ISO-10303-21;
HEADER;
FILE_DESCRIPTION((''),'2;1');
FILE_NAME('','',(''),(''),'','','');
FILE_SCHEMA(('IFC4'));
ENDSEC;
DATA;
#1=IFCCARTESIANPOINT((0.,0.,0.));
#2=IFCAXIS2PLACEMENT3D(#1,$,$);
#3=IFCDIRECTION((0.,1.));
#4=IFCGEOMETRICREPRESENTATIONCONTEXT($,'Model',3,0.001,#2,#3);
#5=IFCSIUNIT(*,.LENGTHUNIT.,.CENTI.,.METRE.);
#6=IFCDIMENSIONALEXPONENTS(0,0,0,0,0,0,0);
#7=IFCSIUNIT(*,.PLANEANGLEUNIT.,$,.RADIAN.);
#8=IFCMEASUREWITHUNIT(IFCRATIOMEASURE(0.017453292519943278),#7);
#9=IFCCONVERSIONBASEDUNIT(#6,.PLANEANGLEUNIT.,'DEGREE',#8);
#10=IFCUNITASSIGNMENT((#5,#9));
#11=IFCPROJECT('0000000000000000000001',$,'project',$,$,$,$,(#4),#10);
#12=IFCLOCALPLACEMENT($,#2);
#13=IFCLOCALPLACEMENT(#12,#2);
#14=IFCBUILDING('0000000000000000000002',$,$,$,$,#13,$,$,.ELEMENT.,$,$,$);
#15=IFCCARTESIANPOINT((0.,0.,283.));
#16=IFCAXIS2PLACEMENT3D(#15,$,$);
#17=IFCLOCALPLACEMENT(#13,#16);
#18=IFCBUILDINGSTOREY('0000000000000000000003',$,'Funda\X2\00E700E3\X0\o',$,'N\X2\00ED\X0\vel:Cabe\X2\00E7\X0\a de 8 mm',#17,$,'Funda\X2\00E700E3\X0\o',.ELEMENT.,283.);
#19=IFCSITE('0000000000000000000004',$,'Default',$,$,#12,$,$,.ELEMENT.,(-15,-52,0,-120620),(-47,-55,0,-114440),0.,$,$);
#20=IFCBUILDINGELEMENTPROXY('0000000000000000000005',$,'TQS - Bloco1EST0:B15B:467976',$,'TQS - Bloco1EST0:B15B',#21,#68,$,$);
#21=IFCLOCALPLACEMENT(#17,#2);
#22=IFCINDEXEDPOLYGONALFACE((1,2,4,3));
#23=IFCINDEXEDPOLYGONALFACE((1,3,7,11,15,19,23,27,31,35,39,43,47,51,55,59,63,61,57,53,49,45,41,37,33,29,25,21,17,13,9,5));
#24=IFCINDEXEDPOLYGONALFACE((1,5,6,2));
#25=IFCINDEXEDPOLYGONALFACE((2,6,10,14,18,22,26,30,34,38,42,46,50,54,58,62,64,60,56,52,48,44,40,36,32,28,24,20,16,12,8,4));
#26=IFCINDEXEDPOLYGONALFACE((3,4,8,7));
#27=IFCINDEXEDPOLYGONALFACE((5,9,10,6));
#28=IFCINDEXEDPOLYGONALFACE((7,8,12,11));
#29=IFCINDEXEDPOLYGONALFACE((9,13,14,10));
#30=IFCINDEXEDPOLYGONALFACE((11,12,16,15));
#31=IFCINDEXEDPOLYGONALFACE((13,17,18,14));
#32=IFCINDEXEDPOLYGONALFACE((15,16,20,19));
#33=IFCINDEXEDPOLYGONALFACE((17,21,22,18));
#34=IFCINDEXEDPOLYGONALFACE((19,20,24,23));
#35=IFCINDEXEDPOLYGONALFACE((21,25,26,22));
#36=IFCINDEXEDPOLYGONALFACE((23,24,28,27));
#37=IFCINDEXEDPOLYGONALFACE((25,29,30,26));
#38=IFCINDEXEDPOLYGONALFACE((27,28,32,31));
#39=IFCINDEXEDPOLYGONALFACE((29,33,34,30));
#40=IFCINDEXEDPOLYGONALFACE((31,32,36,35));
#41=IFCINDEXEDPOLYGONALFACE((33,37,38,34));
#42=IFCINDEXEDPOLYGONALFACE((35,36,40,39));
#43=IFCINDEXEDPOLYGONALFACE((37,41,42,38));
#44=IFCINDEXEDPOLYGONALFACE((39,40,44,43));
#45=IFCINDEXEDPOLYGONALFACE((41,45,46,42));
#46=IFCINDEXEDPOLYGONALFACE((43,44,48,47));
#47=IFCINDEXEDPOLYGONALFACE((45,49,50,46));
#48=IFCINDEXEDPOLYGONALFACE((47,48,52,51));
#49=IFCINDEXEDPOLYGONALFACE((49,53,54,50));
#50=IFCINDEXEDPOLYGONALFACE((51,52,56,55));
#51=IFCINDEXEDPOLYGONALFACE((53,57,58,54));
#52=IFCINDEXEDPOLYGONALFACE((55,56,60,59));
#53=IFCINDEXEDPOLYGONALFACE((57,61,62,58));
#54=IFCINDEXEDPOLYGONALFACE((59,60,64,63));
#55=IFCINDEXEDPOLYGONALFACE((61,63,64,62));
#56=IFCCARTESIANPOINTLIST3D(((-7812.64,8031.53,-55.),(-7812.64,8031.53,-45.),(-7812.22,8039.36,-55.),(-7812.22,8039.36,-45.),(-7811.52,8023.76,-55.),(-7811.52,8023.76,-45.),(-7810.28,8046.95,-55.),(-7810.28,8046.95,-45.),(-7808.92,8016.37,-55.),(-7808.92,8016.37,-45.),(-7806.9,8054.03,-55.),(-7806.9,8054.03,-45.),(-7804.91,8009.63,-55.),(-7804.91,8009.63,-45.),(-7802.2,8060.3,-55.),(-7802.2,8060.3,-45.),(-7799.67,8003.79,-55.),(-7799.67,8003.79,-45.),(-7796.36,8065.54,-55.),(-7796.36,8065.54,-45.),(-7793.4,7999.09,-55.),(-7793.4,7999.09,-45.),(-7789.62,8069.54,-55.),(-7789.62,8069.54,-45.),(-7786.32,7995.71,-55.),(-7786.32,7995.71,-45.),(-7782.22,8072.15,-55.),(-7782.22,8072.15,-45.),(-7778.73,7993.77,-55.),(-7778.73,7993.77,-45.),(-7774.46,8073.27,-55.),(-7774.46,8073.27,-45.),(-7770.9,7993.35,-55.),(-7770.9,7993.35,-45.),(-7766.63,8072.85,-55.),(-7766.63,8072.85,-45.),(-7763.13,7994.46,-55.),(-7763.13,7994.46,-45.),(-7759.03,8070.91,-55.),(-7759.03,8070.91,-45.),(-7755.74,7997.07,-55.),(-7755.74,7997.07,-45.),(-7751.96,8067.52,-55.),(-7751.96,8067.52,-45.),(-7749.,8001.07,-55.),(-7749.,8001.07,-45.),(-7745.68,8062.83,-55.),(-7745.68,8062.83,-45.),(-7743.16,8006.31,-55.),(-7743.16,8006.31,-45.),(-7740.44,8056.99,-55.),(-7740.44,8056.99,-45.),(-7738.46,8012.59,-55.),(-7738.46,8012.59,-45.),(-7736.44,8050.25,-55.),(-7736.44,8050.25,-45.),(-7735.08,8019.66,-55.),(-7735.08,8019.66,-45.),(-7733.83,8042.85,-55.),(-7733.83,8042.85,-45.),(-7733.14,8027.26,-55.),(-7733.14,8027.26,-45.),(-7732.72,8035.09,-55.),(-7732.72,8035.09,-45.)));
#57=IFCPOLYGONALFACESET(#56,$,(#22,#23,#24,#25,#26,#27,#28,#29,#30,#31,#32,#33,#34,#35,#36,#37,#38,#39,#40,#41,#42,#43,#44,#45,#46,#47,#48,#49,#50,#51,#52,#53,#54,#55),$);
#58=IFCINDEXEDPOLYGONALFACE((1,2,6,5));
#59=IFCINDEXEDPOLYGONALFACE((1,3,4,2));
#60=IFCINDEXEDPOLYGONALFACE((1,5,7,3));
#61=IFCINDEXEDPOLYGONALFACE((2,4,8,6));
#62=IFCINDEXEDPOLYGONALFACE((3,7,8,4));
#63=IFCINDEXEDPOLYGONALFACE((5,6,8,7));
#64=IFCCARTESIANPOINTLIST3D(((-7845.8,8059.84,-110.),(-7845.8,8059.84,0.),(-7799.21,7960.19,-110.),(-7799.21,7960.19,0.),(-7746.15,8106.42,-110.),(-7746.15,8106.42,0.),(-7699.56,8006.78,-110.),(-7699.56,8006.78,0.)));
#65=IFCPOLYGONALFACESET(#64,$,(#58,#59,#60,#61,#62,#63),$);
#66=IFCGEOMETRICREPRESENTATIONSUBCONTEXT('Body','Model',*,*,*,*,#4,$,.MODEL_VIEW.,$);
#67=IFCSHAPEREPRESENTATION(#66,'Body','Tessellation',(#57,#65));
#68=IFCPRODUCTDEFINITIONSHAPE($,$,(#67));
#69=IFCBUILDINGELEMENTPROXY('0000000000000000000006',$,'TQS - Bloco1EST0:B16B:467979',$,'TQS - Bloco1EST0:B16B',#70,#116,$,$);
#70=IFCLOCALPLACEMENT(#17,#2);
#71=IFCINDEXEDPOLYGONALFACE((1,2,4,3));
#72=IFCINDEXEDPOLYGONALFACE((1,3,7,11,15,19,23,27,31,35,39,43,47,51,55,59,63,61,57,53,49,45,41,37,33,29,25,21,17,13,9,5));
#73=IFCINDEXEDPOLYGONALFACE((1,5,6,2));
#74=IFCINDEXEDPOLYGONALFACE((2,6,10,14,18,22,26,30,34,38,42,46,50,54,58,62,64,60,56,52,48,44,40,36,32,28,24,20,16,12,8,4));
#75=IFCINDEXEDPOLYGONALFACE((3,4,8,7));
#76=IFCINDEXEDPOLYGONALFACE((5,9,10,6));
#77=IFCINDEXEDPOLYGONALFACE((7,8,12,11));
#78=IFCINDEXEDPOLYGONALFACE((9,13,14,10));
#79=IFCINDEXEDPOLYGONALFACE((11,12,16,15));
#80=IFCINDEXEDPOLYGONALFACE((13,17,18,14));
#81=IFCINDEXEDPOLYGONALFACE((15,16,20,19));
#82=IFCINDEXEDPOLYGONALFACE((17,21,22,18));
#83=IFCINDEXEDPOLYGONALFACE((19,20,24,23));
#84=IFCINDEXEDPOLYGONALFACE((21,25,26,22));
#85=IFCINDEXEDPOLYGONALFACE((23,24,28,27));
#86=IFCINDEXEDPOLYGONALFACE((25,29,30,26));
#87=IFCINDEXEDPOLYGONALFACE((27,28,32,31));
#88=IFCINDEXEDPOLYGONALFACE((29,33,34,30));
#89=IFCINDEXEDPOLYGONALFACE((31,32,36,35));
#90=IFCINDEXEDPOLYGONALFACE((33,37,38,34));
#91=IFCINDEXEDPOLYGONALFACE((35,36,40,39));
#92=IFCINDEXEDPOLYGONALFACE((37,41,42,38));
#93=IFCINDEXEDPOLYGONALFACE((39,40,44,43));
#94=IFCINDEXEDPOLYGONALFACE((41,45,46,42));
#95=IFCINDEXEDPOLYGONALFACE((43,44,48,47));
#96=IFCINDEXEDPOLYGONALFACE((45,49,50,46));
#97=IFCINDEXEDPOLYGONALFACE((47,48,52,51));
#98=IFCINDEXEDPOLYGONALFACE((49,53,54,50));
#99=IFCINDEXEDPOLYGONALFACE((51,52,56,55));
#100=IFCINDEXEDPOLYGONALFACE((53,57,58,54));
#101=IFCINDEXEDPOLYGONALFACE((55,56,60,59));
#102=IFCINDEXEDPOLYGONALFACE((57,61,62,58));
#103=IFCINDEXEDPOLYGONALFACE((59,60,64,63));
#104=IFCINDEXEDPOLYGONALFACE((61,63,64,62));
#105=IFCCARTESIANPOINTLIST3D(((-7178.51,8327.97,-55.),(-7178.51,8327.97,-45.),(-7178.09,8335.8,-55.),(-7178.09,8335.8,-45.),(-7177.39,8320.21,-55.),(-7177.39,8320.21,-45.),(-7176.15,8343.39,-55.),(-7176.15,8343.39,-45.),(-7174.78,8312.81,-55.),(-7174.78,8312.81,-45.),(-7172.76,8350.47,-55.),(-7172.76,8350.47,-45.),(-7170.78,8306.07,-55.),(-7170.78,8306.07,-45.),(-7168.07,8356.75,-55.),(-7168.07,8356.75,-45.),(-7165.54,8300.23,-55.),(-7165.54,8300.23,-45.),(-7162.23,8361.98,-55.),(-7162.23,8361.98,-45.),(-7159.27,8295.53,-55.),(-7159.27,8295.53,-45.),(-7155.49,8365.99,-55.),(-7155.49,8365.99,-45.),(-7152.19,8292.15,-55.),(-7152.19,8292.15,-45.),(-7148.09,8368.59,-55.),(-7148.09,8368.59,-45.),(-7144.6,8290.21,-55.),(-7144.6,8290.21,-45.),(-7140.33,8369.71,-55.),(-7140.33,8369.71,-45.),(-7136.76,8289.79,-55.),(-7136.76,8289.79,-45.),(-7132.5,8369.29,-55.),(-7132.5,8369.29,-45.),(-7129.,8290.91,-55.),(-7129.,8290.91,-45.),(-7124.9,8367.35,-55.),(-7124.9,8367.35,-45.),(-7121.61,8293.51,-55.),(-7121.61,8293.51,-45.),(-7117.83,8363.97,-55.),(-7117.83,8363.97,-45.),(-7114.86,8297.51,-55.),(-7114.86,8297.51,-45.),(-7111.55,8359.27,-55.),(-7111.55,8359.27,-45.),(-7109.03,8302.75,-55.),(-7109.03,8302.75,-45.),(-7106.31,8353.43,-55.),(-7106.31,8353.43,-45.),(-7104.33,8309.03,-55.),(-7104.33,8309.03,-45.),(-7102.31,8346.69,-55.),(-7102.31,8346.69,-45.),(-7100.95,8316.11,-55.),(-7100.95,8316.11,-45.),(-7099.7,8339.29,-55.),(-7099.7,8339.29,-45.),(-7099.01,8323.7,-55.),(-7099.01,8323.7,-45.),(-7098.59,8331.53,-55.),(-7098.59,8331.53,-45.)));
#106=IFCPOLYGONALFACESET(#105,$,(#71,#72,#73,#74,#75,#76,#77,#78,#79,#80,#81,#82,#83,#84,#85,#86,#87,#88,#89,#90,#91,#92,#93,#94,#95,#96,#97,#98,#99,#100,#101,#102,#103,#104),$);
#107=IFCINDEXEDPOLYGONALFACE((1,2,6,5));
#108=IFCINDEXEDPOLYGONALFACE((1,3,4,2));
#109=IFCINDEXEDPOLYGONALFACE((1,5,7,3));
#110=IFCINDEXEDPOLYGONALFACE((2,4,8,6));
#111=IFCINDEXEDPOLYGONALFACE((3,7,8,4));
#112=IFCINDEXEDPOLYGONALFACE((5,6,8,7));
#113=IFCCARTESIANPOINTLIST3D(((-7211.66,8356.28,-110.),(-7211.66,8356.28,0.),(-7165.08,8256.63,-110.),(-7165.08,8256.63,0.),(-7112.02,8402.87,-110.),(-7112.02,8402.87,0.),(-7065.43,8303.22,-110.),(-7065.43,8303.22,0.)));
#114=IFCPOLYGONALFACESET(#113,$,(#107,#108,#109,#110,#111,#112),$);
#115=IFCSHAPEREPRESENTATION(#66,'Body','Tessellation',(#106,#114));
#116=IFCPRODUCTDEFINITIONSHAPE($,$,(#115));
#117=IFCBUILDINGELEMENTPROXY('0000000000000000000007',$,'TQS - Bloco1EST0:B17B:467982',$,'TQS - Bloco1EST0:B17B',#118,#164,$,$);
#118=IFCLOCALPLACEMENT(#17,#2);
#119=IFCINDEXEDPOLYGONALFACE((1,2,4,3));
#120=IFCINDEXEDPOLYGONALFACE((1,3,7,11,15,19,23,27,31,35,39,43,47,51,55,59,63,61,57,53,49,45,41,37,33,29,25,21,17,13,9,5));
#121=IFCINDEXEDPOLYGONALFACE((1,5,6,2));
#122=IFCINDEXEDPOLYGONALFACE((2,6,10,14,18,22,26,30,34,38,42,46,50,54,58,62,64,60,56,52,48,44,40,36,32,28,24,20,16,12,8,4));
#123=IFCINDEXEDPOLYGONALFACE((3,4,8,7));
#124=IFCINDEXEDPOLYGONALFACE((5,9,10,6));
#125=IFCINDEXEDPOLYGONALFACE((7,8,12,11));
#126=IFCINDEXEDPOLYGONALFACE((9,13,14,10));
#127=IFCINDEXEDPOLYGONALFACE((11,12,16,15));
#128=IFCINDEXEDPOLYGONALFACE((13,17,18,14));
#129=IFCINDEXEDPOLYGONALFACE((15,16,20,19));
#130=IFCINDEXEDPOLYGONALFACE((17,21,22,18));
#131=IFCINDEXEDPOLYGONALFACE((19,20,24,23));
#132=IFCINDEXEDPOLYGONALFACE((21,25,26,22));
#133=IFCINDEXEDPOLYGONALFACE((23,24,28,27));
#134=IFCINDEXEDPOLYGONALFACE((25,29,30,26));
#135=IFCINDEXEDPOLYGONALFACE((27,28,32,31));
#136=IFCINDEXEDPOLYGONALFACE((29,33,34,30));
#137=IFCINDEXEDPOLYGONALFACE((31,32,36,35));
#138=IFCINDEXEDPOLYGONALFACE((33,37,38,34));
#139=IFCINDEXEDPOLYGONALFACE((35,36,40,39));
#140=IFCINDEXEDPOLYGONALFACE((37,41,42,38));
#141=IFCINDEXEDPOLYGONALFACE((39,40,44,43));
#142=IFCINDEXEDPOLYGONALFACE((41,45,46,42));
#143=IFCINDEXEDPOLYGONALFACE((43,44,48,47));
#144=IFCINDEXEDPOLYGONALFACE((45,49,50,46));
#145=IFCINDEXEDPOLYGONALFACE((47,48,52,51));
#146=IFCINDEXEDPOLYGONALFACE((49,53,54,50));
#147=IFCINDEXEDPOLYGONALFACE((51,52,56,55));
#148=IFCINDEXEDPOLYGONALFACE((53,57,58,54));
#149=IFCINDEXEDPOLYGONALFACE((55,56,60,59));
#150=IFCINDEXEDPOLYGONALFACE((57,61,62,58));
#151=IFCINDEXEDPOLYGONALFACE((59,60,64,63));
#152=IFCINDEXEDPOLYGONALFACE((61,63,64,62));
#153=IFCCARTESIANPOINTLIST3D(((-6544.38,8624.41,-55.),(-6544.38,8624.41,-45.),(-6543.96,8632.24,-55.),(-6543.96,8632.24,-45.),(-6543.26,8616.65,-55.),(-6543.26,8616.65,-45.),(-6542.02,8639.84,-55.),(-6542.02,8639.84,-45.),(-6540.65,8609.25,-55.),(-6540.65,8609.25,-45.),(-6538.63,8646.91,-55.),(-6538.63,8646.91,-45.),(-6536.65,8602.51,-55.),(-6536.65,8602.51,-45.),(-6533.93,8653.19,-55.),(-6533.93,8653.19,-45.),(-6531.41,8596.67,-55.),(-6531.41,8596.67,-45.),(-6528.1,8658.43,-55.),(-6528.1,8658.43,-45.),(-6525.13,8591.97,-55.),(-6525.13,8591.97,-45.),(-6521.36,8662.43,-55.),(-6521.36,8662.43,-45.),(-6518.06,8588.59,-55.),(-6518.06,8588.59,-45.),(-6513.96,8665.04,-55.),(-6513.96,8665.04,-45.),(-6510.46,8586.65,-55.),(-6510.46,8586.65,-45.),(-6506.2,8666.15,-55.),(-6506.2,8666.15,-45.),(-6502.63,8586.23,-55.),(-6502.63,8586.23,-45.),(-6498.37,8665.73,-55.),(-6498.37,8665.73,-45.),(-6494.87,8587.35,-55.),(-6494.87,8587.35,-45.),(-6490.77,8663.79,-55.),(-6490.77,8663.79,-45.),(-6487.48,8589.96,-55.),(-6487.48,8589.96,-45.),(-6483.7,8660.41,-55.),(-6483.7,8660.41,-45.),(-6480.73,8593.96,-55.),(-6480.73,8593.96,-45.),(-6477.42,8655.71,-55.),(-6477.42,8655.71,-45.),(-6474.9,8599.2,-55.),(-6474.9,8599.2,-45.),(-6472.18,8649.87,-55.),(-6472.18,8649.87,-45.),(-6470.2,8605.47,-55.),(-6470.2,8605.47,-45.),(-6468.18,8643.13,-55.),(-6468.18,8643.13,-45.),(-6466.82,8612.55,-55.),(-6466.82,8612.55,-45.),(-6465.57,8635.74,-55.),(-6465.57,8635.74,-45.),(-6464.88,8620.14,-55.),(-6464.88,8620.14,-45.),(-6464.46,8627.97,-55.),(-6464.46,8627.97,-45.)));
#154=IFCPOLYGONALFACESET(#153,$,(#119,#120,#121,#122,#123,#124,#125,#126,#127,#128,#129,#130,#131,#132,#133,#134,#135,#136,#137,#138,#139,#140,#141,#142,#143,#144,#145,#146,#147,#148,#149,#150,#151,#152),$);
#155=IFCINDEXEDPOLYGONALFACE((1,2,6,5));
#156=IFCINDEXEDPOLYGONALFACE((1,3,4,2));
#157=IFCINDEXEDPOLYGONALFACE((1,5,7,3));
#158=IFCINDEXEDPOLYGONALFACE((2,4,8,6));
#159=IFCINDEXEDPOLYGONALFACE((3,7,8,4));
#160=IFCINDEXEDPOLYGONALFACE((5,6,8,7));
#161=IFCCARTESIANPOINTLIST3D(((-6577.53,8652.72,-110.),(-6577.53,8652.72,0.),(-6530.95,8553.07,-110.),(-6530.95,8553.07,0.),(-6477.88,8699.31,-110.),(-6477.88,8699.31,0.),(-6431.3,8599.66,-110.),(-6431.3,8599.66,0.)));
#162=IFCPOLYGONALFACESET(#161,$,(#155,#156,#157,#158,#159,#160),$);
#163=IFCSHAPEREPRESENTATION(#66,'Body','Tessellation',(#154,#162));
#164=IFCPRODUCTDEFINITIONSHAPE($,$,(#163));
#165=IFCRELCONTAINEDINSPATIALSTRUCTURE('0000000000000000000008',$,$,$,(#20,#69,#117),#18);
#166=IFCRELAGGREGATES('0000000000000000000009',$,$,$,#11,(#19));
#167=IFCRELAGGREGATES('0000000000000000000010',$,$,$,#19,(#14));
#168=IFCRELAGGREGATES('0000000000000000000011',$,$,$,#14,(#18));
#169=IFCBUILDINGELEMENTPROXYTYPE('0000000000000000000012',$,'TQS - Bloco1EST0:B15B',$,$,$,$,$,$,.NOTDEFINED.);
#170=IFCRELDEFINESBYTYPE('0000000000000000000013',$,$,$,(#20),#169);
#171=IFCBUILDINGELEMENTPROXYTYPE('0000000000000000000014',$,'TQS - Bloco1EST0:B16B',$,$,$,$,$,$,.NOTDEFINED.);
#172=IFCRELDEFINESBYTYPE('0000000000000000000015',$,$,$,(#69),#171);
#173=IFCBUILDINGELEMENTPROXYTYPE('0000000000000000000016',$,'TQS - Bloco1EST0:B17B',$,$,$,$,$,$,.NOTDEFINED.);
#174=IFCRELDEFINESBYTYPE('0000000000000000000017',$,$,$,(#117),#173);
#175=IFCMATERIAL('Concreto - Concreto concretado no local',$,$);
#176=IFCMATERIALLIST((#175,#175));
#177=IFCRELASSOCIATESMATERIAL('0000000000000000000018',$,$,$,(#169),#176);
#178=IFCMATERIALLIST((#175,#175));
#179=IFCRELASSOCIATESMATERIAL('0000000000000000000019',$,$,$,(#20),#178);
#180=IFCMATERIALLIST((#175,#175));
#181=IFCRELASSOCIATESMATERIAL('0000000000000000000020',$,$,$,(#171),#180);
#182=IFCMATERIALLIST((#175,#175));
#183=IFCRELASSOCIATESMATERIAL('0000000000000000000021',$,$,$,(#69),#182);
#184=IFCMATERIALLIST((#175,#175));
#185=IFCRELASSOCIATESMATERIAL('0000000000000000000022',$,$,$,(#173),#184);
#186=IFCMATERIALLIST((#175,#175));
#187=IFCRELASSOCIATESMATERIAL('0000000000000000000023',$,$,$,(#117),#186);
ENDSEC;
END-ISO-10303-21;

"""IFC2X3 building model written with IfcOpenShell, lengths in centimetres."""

from ifc_helpers import new_model, entity, si_unit, converted_unit, direction, frame, frame_2d, origin, origin_2d_with_axis, place, context, subcontext, project, spatial, rectangle, circle, extrude, source, transform, mapped, material, material_list, type_object, type_shapes, element, save


model = new_model("IFC2X3")

# Units and contexts
model_context = context("Model", 3, precision=0.001, world=origin(), true_north=direction((0.0, 1.0)))
body_context = subcontext(model_context, "Body", "Model", "MODEL_VIEW")
ifc_project = project(units=[si_unit("LENGTHUNIT", "METRE", prefix="CENTI"), converted_unit("PLANEANGLEUNIT", "DEGREE", entity("IfcRatioMeasure", 0.017453292519943278), si_unit("PLANEANGLEUNIT", "RADIAN"), dimensions=[0, 0, 0, 0, 0, 0, 0])], contexts=[model_context])

# Site, building, storey
site_placement = place(None, origin())
site = spatial("IfcSite", under=ifc_project, at=site_placement, Name="Default", CompositionType="ELEMENT", RefLatitude=(-15, -52, 0, -120620), RefLongitude=(-47, -55, 0, -114440), RefElevation=0.0)
building_placement = place(site_placement, origin())
building = spatial("IfcBuilding", under=site, at=building_placement, CompositionType="ELEMENT")
storey_placement = place(building_placement, frame((0.0, 0.0, 283.0)))
storey = spatial("IfcBuildingStorey", under=building, at=storey_placement, Name="Fundação", ObjectType="Nível:Cabeça de 8 mm", LongName="Fundação", CompositionType="ELEMENT", Elevation=283.0)

# Building element proxies
ifc_material_1 = material(Name="Concreto - Concreto concretado no local")
ifc_material_list_1 = material_list([ifc_material_1, ifc_material_1])
ifc_material_list_2 = material_list([ifc_material_1, ifc_material_1])
building_element_proxy_type_1 = type_object("IfcBuildingElementProxyType", Name="TQS - Bloco1EST0:B15B", PredefinedType="NOTDEFINED", material=ifc_material_list_2)
shared_shape_1 = source(origin(), body_context, "Body", "SweptSolid", [
    extrude(circle(Radius=40.0, at=frame_2d((0.0, 0.0), x_axis=(1.0, 0.0))), frame((0.0, 0.0, -55.0)), (0.0, 0.0, 1.0), 10.0),
    extrude(rectangle(XDim=110.0, YDim=110.0, at=origin_2d_with_axis()), frame((0.0, 0.0, -110.0), z_axis=(0.0, 0.0, 1.0), x_axis=(-1.0, 0.0, 0.0)), (0.0, 0.0, 1.0), 110.0),
])
type_shapes(building_element_proxy_type_1, [shared_shape_1])
proxy_1_placement = place(storey_placement, frame((-7772.68, 8033.31, 0.0), z_axis=(0.0, 0.0, 1.0), x_axis=(0.905902, 0.423488, 0.0)))
element("IfcBuildingElementProxy", 1, at=proxy_1_placement, inside=storey, type_object=building_element_proxy_type_1, material=ifc_material_list_1, Name="TQS - Bloco1EST0:B15B:467976", ObjectType="TQS - Bloco1EST0:B15B", context=body_context, shape_type="MappedRepresentation", body=[
    mapped(shared_shape_1, transform((0.0, 0.0, 0.0), scale=1.0)),
])
ifc_material_list_3 = material_list([ifc_material_1, ifc_material_1])
ifc_material_list_4 = material_list([ifc_material_1, ifc_material_1])
building_element_proxy_type_2 = type_object("IfcBuildingElementProxyType", Name="TQS - Bloco1EST0:B16B", PredefinedType="NOTDEFINED", material=ifc_material_list_4)
shared_shape_2 = source(origin(), body_context, "Body", "SweptSolid", [
    extrude(circle(Radius=40.0, at=frame_2d((0.0, 0.0), x_axis=(1.0, 0.0))), frame((0.0, 0.0, -55.0)), (0.0, 0.0, 1.0), 10.0),
    extrude(rectangle(XDim=110.0, YDim=110.0, at=origin_2d_with_axis()), frame((0.0, 0.0, -110.0), z_axis=(0.0, 0.0, 1.0), x_axis=(-1.0, 0.0, 0.0)), (0.0, 0.0, 1.0), 110.0),
])
type_shapes(building_element_proxy_type_2, [shared_shape_2])
proxy_2_placement = place(storey_placement, frame((-7138.55, 8329.75, 0.0), z_axis=(0.0, 0.0, 1.0), x_axis=(0.905902, 0.423488, 0.0)))
element("IfcBuildingElementProxy", 2, at=proxy_2_placement, inside=storey, type_object=building_element_proxy_type_2, material=ifc_material_list_3, Name="TQS - Bloco1EST0:B16B:467979", ObjectType="TQS - Bloco1EST0:B16B", context=body_context, shape_type="MappedRepresentation", body=[
    mapped(shared_shape_2, transform((0.0, 0.0, 0.0), scale=1.0)),
])
ifc_material_list_5 = material_list([ifc_material_1, ifc_material_1])
ifc_material_list_6 = material_list([ifc_material_1, ifc_material_1])
building_element_proxy_type_3 = type_object("IfcBuildingElementProxyType", Name="TQS - Bloco1EST0:B17B", PredefinedType="NOTDEFINED", material=ifc_material_list_6)
shared_shape_3 = source(origin(), body_context, "Body", "SweptSolid", [
    extrude(circle(Radius=40.0, at=frame_2d((0.0, 0.0), x_axis=(1.0, 0.0))), frame((0.0, 0.0, -55.0)), (0.0, 0.0, 1.0), 10.0),
    extrude(rectangle(XDim=110.0, YDim=110.0, at=origin_2d_with_axis()), frame((0.0, 0.0, -110.0), z_axis=(0.0, 0.0, 1.0), x_axis=(-1.0, 0.0, 0.0)), (0.0, 0.0, 1.0), 110.0),
])
type_shapes(building_element_proxy_type_3, [shared_shape_3])
proxy_3_placement = place(storey_placement, frame((-6504.42, 8626.19, 0.0), z_axis=(0.0, 0.0, 1.0), x_axis=(0.905902, 0.423488, 0.0)))
element("IfcBuildingElementProxy", 3, at=proxy_3_placement, inside=storey, type_object=building_element_proxy_type_3, material=ifc_material_list_5, Name="TQS - Bloco1EST0:B17B:467982", ObjectType="TQS - Bloco1EST0:B17B", context=body_context, shape_type="MappedRepresentation", body=[
    mapped(shared_shape_3, transform((0.0, 0.0, 0.0), scale=1.0)),
])

save(model, "model.ifc")
